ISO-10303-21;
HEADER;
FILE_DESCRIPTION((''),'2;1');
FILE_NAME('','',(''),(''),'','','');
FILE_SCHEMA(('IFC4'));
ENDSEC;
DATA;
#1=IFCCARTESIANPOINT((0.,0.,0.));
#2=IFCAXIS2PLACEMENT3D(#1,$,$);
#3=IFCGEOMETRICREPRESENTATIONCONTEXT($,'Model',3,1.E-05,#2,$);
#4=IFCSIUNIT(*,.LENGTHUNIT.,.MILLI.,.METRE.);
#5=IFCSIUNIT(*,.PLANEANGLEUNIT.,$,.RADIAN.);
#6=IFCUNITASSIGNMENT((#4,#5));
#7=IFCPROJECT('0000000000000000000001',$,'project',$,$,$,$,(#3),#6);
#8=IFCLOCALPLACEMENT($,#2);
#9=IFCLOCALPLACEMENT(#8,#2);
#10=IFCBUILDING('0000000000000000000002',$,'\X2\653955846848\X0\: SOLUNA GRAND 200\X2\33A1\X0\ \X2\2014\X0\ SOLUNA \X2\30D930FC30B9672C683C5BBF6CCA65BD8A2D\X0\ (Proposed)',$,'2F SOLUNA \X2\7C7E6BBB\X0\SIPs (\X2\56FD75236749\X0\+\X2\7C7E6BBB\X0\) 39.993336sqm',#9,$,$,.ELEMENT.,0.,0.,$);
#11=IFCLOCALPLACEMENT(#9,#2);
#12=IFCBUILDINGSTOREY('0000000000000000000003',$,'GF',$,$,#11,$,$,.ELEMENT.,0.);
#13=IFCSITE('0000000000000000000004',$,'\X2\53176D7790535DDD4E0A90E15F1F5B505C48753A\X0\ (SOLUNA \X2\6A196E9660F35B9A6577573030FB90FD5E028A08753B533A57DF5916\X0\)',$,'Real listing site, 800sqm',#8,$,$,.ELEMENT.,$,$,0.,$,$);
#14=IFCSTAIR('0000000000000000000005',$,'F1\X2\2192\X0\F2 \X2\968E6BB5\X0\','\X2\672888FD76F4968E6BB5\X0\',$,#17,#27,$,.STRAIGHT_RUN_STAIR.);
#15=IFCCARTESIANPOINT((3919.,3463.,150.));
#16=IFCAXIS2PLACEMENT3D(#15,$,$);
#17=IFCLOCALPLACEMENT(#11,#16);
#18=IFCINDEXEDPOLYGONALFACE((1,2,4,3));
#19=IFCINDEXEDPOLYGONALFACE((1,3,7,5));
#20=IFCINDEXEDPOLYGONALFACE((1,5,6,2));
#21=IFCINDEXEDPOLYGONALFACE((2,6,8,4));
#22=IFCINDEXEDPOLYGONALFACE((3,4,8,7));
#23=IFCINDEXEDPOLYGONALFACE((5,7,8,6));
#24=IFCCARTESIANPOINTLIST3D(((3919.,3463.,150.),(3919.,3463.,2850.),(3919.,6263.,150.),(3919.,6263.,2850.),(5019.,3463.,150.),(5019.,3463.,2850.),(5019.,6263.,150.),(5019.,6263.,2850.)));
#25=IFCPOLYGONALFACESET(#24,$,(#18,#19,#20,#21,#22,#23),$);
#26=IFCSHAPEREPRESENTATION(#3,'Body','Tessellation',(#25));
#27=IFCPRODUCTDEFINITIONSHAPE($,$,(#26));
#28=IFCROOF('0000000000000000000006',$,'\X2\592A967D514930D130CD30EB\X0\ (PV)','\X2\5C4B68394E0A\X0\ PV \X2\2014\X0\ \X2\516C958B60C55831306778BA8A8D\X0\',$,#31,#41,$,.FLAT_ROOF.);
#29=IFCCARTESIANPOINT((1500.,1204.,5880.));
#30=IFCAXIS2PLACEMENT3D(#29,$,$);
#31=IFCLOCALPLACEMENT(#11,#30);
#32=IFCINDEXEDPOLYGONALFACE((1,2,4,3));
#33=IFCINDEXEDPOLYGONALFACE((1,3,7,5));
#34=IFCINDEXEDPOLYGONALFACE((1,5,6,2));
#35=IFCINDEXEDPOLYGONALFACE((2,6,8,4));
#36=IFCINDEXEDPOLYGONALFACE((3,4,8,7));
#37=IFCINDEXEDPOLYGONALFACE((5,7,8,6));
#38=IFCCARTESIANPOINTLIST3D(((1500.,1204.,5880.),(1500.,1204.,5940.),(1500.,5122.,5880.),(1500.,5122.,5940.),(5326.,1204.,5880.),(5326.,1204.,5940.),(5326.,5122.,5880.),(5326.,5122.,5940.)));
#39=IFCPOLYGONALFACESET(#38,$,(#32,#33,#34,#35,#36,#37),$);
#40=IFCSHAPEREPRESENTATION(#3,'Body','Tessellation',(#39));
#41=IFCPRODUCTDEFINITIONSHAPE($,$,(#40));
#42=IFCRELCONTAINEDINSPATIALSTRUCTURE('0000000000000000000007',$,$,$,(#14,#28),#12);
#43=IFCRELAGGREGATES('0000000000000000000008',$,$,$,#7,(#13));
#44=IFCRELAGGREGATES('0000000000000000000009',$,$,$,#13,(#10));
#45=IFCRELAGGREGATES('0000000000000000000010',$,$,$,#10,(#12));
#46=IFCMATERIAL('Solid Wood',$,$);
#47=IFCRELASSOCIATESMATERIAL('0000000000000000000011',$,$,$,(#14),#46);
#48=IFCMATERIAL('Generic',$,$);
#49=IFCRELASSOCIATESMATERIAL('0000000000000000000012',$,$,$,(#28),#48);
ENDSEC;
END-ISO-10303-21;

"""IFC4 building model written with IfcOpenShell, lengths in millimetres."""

from ifc_helpers import new_model, si_unit, frame, frame_2d, origin, place, context, project, spatial, rectangle, extrude, material, element, save


model = new_model("IFC4")

# Units and contexts
model_context = context("Model", 3, precision=1e-05, world=origin())
ifc_project = project(units=[si_unit("LENGTHUNIT", "METRE", prefix="MILLI"), si_unit("PLANEANGLEUNIT", "RADIAN")], contexts=[model_context])

# Site, building, storey
site_placement = place(None, origin())
site = spatial("IfcSite", under=ifc_project, at=site_placement, Name="北海道川上郡弟子屈町 (SOLUNA 標準想定敷地・都市計画区域外)", ObjectType="Real listing site, 800sqm", CompositionType="ELEMENT", RefElevation=0.0)
building_placement = place(site_placement, origin())
building = spatial("IfcBuilding", under=site, at=building_placement, Name="改善案: SOLUNA GRAND 200㎡ — SOLUNA ベース本格宿泊施設 (Proposed)", ObjectType="2F SOLUNA 籾殻SIPs (国産杉+籾殻) 39.993336sqm", CompositionType="ELEMENT", ElevationOfRefHeight=0.0, ElevationOfTerrain=0.0)
storey_placement = place(building_placement, origin())
storey = spatial("IfcBuildingStorey", under=building, at=storey_placement, Name="GF", CompositionType="ELEMENT", Elevation=0.0)

# Shared definitions
ifc_material_1 = material(Name="Generic")

# Stair
ifc_material_2 = material(Name="Solid Wood")
stair_placement = place(storey_placement, frame((3919.0, 3463.0, 150.0)))
element("IfcStair", 1, at=stair_placement, inside=storey, material=ifc_material_2, Name="F1→F2 階段", Description="木製直階段", PredefinedType="STRAIGHT_RUN_STAIR", context=model_context, shape_type="SweptSolid", body=[
    extrude(rectangle(XDim=1100.0, YDim=2800.0, at=frame_2d((550.0, 1400.0))), frame((3919.0, 3463.0, 150.0)), (0.0, 0.0, 1.0), 2700.0),
])

# Roof
roof_placement = place(storey_placement, frame((1500.0, 1204.0, 5880.0)))
element("IfcRoof", 2, at=roof_placement, inside=storey, material=ifc_material_1, Name="太陽光パネル (PV)", Description="屋根上 PV — 公開情報で確認", PredefinedType="FLAT_ROOF", context=model_context, shape_type="SweptSolid", body=[
    extrude(rectangle(XDim=3826.0, YDim=3918.0, at=frame_2d((1913.0, 1959.0))), frame((1500.0, 1204.0, 5880.0)), (0.0, 0.0, 1.0), 60.0),
])

save(model, "model.ifc")
